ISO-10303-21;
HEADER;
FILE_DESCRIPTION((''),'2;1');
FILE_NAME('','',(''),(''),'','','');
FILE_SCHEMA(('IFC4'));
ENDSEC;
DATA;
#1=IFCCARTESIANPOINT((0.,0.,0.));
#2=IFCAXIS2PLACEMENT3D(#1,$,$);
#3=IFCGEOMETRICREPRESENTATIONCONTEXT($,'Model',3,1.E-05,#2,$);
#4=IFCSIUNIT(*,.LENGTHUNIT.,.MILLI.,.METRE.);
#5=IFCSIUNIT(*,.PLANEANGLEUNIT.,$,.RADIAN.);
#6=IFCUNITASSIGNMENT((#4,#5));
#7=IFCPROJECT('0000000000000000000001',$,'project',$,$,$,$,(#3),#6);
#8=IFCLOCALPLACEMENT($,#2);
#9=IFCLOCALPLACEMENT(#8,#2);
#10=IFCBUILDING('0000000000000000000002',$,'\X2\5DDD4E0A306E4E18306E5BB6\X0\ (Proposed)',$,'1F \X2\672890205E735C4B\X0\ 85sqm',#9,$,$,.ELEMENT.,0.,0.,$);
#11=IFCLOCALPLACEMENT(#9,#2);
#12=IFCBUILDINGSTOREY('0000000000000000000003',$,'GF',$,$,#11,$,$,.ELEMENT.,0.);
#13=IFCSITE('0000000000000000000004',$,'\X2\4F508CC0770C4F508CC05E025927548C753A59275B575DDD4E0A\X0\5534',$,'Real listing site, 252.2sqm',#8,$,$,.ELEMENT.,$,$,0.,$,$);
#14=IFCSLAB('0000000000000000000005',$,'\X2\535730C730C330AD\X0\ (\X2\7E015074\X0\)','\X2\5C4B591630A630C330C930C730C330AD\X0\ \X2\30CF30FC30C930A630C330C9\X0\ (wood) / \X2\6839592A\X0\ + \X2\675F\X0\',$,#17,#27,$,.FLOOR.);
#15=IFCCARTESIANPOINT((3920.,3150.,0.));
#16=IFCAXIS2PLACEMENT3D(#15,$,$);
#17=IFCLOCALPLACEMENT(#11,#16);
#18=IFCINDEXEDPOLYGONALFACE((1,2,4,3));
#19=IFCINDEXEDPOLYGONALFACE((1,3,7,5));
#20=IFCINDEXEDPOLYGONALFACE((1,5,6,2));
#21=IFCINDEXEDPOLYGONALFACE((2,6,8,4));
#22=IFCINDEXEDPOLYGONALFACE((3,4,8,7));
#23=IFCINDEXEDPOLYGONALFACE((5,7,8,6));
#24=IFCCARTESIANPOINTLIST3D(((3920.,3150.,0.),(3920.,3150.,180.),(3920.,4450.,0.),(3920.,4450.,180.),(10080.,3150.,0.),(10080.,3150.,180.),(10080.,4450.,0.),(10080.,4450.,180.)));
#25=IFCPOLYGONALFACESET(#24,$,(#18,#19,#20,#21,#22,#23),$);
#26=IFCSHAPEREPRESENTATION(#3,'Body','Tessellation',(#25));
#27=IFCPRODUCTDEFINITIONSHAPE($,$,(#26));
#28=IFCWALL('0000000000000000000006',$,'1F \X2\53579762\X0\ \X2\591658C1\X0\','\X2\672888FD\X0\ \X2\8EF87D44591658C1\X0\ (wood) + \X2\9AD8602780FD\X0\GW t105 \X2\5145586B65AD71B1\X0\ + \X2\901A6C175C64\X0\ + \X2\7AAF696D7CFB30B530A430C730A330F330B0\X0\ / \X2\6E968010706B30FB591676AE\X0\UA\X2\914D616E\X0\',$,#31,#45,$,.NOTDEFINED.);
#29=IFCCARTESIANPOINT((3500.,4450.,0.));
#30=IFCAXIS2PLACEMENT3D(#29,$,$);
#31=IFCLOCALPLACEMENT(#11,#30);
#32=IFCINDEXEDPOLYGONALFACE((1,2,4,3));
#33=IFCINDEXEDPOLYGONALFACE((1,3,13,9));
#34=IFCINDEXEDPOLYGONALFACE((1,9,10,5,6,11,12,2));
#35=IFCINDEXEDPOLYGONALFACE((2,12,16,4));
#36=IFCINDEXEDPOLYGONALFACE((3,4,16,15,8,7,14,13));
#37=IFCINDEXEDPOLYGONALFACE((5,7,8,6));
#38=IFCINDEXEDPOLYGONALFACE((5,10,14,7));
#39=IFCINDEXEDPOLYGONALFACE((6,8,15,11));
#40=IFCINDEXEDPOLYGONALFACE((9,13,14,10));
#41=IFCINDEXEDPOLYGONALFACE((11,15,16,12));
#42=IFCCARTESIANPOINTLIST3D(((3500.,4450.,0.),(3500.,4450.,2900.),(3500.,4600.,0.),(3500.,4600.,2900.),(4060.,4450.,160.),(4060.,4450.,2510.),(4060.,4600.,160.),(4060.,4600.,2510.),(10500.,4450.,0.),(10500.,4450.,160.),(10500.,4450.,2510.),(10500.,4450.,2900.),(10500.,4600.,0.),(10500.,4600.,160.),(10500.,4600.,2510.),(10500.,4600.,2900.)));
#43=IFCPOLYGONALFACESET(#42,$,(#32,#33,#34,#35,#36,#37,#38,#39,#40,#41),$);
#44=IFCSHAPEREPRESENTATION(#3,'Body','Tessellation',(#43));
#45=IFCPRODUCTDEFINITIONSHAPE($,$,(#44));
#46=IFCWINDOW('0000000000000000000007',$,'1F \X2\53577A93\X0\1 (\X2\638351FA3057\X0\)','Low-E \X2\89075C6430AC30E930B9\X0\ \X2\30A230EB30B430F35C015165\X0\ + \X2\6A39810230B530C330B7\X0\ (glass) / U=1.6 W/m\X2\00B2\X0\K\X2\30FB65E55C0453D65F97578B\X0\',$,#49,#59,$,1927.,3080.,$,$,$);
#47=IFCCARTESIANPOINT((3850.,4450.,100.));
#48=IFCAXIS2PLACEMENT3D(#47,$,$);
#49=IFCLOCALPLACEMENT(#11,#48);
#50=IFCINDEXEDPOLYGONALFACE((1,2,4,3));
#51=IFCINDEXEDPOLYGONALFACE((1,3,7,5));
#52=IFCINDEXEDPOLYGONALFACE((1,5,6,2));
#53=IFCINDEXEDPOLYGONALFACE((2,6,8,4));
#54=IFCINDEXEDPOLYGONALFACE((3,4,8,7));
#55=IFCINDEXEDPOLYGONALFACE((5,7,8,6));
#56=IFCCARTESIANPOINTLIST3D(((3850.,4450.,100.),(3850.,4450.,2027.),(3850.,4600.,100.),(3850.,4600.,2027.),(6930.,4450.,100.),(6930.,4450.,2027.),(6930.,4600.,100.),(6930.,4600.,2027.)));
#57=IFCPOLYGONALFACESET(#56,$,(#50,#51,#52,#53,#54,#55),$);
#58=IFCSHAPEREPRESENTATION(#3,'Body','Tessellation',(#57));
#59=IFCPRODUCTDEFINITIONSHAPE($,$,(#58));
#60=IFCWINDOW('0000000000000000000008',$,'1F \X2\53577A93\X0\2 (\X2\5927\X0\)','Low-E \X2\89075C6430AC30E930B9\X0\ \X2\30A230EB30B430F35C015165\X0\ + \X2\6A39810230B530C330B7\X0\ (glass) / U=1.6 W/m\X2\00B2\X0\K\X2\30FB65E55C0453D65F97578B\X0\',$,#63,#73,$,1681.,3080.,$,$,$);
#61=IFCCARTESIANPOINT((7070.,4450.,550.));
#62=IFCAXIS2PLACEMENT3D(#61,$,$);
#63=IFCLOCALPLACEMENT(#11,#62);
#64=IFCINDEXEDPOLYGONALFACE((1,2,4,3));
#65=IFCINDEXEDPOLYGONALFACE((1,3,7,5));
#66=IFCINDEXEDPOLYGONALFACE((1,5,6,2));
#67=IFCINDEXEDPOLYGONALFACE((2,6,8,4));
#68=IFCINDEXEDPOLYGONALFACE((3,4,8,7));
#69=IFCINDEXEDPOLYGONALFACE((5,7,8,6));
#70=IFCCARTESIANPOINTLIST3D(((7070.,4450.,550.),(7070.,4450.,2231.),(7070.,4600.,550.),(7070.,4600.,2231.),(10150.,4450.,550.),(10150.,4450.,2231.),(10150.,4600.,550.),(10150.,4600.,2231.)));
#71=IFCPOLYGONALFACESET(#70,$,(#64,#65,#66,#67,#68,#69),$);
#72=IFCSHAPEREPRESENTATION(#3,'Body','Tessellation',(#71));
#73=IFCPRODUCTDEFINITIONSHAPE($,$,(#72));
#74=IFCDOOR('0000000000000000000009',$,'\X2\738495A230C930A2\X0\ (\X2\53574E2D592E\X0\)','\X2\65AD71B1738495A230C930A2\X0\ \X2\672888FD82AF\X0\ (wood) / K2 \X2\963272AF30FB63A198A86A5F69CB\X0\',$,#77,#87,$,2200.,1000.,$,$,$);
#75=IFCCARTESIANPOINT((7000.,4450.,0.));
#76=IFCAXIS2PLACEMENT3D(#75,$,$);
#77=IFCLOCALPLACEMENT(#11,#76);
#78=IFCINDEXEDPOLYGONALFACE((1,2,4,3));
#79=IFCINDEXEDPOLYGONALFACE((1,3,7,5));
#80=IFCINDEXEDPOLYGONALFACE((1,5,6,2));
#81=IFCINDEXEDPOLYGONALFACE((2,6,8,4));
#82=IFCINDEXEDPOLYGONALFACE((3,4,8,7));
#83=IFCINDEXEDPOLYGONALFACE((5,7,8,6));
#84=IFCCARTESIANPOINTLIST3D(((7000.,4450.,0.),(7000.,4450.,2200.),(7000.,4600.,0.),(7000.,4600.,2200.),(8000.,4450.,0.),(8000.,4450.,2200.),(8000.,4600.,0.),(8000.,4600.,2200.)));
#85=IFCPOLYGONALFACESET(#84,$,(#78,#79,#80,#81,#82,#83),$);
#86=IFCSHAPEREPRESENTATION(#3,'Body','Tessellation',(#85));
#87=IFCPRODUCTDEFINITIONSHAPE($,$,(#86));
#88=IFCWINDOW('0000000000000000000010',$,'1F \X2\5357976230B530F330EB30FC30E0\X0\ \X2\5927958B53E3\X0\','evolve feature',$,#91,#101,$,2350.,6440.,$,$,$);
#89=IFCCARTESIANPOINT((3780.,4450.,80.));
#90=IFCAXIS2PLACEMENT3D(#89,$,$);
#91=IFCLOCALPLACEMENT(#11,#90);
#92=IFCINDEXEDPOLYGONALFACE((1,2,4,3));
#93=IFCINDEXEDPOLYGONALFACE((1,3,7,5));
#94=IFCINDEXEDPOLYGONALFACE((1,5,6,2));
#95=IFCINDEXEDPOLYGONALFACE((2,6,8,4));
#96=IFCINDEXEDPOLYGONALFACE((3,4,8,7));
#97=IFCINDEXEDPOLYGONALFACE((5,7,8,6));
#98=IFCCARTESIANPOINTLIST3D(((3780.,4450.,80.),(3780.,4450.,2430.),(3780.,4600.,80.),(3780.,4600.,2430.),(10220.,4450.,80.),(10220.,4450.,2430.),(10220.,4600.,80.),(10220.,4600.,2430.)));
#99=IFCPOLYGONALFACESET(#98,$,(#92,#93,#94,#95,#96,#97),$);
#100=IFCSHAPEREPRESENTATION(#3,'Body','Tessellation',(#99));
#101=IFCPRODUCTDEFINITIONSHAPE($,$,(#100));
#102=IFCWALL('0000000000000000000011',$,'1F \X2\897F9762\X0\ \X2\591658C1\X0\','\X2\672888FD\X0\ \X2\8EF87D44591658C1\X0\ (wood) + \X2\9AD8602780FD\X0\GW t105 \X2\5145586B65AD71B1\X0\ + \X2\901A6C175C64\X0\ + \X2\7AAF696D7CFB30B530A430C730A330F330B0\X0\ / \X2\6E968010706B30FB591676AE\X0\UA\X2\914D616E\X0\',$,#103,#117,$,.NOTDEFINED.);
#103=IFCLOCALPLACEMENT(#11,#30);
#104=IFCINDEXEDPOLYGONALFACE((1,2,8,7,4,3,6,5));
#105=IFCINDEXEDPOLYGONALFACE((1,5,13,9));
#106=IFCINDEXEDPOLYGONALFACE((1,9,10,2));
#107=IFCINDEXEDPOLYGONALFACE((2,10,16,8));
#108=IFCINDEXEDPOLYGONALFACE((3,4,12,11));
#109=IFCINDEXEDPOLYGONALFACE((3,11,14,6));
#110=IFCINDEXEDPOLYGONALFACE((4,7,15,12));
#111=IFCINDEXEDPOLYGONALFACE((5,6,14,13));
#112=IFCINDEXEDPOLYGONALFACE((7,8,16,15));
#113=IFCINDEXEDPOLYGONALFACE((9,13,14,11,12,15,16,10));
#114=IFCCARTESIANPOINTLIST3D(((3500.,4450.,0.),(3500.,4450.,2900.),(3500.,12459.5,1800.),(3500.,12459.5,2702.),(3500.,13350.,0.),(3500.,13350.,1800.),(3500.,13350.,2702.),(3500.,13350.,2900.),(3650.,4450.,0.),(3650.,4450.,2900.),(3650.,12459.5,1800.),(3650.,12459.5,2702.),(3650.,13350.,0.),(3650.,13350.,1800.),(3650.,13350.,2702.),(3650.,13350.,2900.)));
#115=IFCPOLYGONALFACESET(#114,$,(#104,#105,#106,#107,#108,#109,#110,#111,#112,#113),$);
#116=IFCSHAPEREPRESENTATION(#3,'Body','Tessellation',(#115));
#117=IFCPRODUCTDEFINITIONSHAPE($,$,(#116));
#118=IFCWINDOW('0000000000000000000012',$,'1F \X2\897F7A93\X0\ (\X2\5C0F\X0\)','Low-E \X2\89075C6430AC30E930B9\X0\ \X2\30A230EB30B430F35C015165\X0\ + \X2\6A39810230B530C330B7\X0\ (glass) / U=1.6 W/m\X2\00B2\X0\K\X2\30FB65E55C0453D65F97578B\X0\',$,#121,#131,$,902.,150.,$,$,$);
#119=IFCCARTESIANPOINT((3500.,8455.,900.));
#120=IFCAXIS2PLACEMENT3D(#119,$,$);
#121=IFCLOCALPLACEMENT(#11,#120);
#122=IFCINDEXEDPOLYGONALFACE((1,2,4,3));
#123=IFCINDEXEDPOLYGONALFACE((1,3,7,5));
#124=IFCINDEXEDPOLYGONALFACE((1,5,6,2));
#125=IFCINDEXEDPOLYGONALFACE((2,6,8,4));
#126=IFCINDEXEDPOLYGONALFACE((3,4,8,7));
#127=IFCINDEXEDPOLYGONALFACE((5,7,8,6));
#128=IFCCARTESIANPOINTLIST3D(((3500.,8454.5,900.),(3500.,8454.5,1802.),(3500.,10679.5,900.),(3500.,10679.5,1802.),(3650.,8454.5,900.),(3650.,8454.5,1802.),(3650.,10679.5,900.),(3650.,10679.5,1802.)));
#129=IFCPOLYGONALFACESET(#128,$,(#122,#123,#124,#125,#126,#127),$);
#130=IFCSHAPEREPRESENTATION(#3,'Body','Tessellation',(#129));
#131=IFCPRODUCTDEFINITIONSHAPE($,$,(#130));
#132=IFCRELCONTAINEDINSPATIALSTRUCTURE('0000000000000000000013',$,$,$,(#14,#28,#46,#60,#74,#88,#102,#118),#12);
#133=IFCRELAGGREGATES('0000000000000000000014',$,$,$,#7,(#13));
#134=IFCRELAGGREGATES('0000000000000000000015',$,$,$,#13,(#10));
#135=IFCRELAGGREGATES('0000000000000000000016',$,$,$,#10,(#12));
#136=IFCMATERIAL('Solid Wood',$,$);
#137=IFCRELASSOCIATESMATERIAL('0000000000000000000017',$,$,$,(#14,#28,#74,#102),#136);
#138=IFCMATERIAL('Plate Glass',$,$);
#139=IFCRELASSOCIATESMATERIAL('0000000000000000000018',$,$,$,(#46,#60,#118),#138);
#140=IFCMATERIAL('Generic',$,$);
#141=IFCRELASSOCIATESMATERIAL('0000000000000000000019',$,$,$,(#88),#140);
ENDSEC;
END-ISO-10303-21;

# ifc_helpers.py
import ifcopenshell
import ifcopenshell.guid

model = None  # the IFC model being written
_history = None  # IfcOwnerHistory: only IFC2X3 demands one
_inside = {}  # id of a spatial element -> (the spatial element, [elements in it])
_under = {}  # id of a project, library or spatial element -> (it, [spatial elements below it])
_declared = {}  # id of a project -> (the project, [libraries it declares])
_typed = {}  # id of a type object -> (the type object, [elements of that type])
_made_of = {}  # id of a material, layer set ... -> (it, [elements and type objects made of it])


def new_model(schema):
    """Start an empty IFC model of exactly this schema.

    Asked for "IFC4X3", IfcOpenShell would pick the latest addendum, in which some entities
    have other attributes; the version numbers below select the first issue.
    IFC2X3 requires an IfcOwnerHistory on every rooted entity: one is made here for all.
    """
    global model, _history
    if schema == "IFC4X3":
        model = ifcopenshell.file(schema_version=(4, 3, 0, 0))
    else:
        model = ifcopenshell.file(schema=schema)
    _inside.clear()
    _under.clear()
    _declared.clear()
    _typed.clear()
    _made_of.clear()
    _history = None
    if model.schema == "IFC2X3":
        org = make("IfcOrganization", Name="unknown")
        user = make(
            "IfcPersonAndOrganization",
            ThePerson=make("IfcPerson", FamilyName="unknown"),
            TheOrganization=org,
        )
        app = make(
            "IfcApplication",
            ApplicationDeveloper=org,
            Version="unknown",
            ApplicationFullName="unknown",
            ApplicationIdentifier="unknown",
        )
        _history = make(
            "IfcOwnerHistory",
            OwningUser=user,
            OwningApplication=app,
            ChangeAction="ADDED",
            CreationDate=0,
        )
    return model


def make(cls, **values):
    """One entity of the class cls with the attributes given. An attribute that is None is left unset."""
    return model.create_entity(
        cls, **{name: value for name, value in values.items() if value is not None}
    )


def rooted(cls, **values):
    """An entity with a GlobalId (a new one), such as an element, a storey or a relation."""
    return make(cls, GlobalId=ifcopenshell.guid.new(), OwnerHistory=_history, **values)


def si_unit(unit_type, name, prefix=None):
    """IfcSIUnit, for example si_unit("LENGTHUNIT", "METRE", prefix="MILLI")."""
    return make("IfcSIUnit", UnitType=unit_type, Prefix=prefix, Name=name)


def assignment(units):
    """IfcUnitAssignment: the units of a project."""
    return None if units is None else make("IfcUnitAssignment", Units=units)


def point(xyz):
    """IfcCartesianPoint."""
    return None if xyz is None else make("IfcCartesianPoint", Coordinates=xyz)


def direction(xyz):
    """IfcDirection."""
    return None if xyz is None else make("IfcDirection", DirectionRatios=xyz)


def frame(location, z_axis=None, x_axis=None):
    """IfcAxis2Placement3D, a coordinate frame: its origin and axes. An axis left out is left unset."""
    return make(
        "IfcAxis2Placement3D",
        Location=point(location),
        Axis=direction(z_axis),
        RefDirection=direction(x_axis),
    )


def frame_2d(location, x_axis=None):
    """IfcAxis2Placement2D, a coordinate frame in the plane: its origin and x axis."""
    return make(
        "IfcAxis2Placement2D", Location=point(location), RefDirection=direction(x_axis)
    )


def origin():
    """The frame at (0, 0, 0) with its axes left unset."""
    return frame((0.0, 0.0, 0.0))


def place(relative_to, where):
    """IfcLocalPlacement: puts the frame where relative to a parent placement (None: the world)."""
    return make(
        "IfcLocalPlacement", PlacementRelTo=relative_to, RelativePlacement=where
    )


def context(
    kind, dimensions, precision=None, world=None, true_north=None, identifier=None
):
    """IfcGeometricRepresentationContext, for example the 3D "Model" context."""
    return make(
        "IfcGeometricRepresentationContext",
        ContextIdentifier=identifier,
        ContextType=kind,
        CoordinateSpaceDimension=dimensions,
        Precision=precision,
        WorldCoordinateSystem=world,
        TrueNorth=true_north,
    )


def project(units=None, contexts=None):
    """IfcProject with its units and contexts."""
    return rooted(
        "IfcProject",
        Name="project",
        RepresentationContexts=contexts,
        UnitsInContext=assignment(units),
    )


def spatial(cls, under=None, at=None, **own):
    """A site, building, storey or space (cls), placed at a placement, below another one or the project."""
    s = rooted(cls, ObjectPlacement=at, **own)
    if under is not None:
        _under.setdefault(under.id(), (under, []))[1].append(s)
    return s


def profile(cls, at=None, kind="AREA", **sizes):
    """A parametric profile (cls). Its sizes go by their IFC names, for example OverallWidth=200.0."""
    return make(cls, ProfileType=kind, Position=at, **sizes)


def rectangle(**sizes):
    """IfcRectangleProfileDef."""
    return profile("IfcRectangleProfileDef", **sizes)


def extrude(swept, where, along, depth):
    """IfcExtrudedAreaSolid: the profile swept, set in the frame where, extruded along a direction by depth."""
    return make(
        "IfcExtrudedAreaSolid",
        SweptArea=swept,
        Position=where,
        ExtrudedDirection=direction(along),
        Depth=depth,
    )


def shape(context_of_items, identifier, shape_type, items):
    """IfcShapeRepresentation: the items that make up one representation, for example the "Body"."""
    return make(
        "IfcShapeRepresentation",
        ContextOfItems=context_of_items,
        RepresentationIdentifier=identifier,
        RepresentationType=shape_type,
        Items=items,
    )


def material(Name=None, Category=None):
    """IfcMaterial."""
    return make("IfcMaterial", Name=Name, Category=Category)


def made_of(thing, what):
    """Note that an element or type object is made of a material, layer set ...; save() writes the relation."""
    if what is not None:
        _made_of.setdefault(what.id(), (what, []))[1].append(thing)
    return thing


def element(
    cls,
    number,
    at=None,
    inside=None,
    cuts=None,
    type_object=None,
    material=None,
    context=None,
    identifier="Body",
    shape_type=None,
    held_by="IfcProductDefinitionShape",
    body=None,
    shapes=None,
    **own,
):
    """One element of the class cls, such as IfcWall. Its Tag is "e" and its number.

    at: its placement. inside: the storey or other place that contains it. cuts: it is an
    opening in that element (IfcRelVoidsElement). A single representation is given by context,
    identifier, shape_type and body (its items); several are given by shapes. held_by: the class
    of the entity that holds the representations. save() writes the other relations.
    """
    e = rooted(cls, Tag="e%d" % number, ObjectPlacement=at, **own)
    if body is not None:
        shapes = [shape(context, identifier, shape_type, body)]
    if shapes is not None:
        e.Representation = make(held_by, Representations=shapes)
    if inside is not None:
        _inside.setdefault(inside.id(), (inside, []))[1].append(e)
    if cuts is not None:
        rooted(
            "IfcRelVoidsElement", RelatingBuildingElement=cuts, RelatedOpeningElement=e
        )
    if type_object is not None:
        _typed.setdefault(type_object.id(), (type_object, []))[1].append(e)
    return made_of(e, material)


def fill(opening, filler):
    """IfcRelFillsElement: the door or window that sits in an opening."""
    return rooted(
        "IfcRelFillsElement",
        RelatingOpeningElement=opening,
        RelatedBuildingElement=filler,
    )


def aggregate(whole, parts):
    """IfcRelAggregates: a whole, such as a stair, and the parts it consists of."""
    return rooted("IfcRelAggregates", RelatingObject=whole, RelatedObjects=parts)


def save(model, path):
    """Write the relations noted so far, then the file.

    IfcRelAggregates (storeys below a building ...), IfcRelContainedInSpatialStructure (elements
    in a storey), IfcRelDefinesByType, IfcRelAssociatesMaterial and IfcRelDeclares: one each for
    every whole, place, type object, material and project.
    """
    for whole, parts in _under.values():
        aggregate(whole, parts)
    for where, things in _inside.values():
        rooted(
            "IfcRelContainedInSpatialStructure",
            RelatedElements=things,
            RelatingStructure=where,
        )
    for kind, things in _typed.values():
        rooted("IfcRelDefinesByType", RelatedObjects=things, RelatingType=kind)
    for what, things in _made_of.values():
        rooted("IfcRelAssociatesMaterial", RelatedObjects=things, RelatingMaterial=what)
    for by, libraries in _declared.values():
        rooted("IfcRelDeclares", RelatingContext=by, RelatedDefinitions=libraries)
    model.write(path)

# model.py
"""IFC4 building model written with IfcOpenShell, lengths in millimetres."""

from ifc_helpers import new_model, si_unit, frame, frame_2d, origin, place, context, project, spatial, rectangle, extrude, material, element, fill, save


model = new_model("IFC4")

# Units and contexts
model_context = context("Model", 3, precision=1e-05, world=origin())
ifc_project = project(units=[si_unit("LENGTHUNIT", "METRE", prefix="MILLI"), si_unit("PLANEANGLEUNIT", "RADIAN")], contexts=[model_context])

# Site, building, storey
site_placement = place(None, origin())
site = spatial("IfcSite", under=ifc_project, at=site_placement, Name="佐賀県佐賀市大和町大字川上5534", ObjectType="Real listing site, 252.2sqm", CompositionType="ELEMENT", RefElevation=0.0)
building_placement = place(site_placement, origin())
building = spatial("IfcBuilding", under=site, at=building_placement, Name="川上の丘の家 (Proposed)", ObjectType="1F 木造平屋 85sqm", CompositionType="ELEMENT", ElevationOfRefHeight=0.0, ElevationOfTerrain=0.0)
storey_placement = place(building_placement, origin())
storey = spatial("IfcBuildingStorey", under=building, at=storey_placement, Name="GF", CompositionType="ELEMENT", Elevation=0.0)

# Slab
ifc_material_1 = material(Name="Solid Wood")
slab_1_placement = place(storey_placement, frame((3920.0, 3150.0, 0.0)))
element("IfcSlab", 1, at=slab_1_placement, inside=storey, material=ifc_material_1, Name="南デッキ (縁側)", Description="屋外ウッドデッキ ハードウッド (wood) / 根太 + 束", PredefinedType="FLOOR", context=model_context, shape_type="SweptSolid", body=[
    extrude(rectangle(XDim=6160.0, YDim=1300.0, at=frame_2d((3080.0, 650.0))), frame((3920.0, 3150.0, 0.0)), (0.0, 0.0, 1.0), 180.0),
])
ifc_material_2 = material(Name="Generic")

# Wall, openings, windows, door
wall_1_placement = place(storey_placement, frame((3500.0, 4450.0, 0.0)))
wall_1 = element("IfcWall", 2, at=wall_1_placement, inside=storey, material=ifc_material_1, Name="1F 南面 外壁", Description="木製 軸組外壁 (wood) + 高性能GW t105 充填断熱 + 通気層 + 窯業系サイディング / 準耐火・外皮UA配慮", PredefinedType="NOTDEFINED", context=model_context, shape_type="SweptSolid", body=[
    extrude(rectangle(XDim=7000.0, YDim=150.0, at=frame_2d((3500.0, 75.0))), frame((3500.0, 4450.0, 0.0)), (0.0, 0.0, 1.0), 2900.0),
])
opening_1_placement = place(storey_placement, frame((3850.0, 4450.0, 100.0)))
opening_1 = element("IfcOpeningElement", 3, at=opening_1_placement, cuts=wall_1, PredefinedType="NOTDEFINED", context=model_context, shape_type="SweptSolid", body=[
    extrude(rectangle(XDim=3080.0, YDim=150.0, at=frame_2d((1540.0, 75.0))), frame((3850.0, 4450.0, 100.0)), (0.0, 0.0, 1.0), 1927.0),
])
opening_2_placement = place(storey_placement, frame((7070.0, 4450.0, 550.0)))
opening_2 = element("IfcOpeningElement", 4, at=opening_2_placement, cuts=wall_1, PredefinedType="NOTDEFINED", context=model_context, shape_type="SweptSolid", body=[
    extrude(rectangle(XDim=3080.0, YDim=150.0, at=frame_2d((1540.0, 75.0))), frame((7070.0, 4450.0, 550.0)), (0.0, 0.0, 1.0), 1681.0),
])
opening_3_placement = place(storey_placement, frame((7000.0, 4450.0, 0.0)))
opening_3 = element("IfcOpeningElement", 5, at=opening_3_placement, cuts=wall_1, PredefinedType="NOTDEFINED", context=model_context, shape_type="SweptSolid", body=[
    extrude(rectangle(XDim=1000.0, YDim=150.0, at=frame_2d((500.0, 75.0))), frame((7000.0, 4450.0, 0.0)), (0.0, 0.0, 1.0), 2200.0),
])
opening_4_placement = place(storey_placement, frame((3780.0, 4450.0, 80.0)))
opening_4 = element("IfcOpeningElement", 6, at=opening_4_placement, cuts=wall_1, PredefinedType="NOTDEFINED", context=model_context, shape_type="SweptSolid", body=[
    extrude(rectangle(XDim=6440.0, YDim=150.0, at=frame_2d((3220.0, 75.0))), frame((3780.0, 4450.0, 80.0)), (0.0, 0.0, 1.0), 2350.0),
])
ifc_material_3 = material(Name="Plate Glass")
window_1_placement = place(storey_placement, frame((3850.0, 4450.0, 100.0)))
window_1 = element("IfcWindow", 7, at=window_1_placement, inside=storey, material=ifc_material_3, Name="1F 南窓1 (掃出し)", Description="Low-E 複層ガラス アルゴン封入 + 樹脂サッシ (glass) / U=1.6 W/m²K・日射取得型", OverallHeight=1927.0, OverallWidth=3080.0, context=model_context, shape_type="SweptSolid", body=[
    extrude(rectangle(XDim=3080.0, YDim=150.0, at=frame_2d((1540.0, 75.0))), frame((3850.0, 4450.0, 100.0)), (0.0, 0.0, 1.0), 1927.0),
])
fill(opening_1, window_1)
window_2_placement = place(storey_placement, frame((7070.0, 4450.0, 550.0)))
window_2 = element("IfcWindow", 8, at=window_2_placement, inside=storey, material=ifc_material_3, Name="1F 南窓2 (大)", Description="Low-E 複層ガラス アルゴン封入 + 樹脂サッシ (glass) / U=1.6 W/m²K・日射取得型", OverallHeight=1681.0, OverallWidth=3080.0, context=model_context, shape_type="SweptSolid", body=[
    extrude(rectangle(XDim=3080.0, YDim=150.0, at=frame_2d((1540.0, 75.0))), frame((7070.0, 4450.0, 550.0)), (0.0, 0.0, 1.0), 1681.0),
])
fill(opening_2, window_2)
door_placement = place(storey_placement, frame((7000.0, 4450.0, 0.0)))
door = element("IfcDoor", 9, at=door_placement, inside=storey, material=ifc_material_1, Name="玄関ドア (南中央)", Description="断熱玄関ドア 木製芯 (wood) / K2 防犯・採風機構", OverallHeight=2200.0, OverallWidth=1000.0, context=model_context, shape_type="SweptSolid", body=[
    extrude(rectangle(XDim=1000.0, YDim=150.0, at=frame_2d((500.0, 75.0))), frame((7000.0, 4450.0, 0.0)), (0.0, 0.0, 1.0), 2200.0),
])
fill(opening_3, door)
window_3_placement = place(storey_placement, frame((3780.0, 4450.0, 80.0)))
window_3 = element("IfcWindow", 10, at=window_3_placement, inside=storey, material=ifc_material_2, Name="1F 南面サンルーム 大開口", Description="evolve feature", OverallHeight=2350.0, OverallWidth=6440.0, context=model_context, shape_type="SweptSolid", body=[
    extrude(rectangle(XDim=6440.0, YDim=150.0, at=frame_2d((3220.0, 75.0))), frame((3780.0, 4450.0, 80.0)), (0.0, 0.0, 1.0), 2350.0),
])
fill(opening_4, window_3)

# Wall, opening, window
wall_2_placement = place(storey_placement, frame((3500.0, 4450.0, 0.0)))
wall_2 = element("IfcWall", 11, at=wall_2_placement, inside=storey, material=ifc_material_1, Name="1F 西面 外壁", Description="木製 軸組外壁 (wood) + 高性能GW t105 充填断熱 + 通気層 + 窯業系サイディング / 準耐火・外皮UA配慮", PredefinedType="NOTDEFINED", context=model_context, shape_type="SweptSolid", body=[
    extrude(rectangle(XDim=150.0, YDim=8900.0, at=frame_2d((75.0, 4450.0))), frame((3500.0, 4450.0, 0.0)), (0.0, 0.0, 1.0), 2900.0),
])
opening_5_placement = place(storey_placement, frame((3500.0, 8455.0, 900.0)))
opening_5 = element("IfcOpeningElement", 12, at=opening_5_placement, cuts=wall_2, PredefinedType="NOTDEFINED", context=model_context, shape_type="SweptSolid", body=[
    extrude(rectangle(XDim=150.0, YDim=2225.0, at=frame_2d((75.0, 1112.0))), frame((3500.0, 8455.0, 900.0)), (0.0, 0.0, 1.0), 902.0),
])
window_4_placement = place(storey_placement, frame((3500.0, 8455.0, 900.0)))
window_4 = element("IfcWindow", 13, at=window_4_placement, inside=storey, material=ifc_material_3, Name="1F 西窓 (小)", Description="Low-E 複層ガラス アルゴン封入 + 樹脂サッシ (glass) / U=1.6 W/m²K・日射取得型", OverallHeight=902.0, OverallWidth=150.0, context=model_context, shape_type="SweptSolid", body=[
    extrude(rectangle(XDim=150.0, YDim=2225.0, at=frame_2d((75.0, 1112.0))), frame((3500.0, 8455.0, 900.0)), (0.0, 0.0, 1.0), 902.0),
])
fill(opening_5, window_4)

save(model, "model.ifc")
